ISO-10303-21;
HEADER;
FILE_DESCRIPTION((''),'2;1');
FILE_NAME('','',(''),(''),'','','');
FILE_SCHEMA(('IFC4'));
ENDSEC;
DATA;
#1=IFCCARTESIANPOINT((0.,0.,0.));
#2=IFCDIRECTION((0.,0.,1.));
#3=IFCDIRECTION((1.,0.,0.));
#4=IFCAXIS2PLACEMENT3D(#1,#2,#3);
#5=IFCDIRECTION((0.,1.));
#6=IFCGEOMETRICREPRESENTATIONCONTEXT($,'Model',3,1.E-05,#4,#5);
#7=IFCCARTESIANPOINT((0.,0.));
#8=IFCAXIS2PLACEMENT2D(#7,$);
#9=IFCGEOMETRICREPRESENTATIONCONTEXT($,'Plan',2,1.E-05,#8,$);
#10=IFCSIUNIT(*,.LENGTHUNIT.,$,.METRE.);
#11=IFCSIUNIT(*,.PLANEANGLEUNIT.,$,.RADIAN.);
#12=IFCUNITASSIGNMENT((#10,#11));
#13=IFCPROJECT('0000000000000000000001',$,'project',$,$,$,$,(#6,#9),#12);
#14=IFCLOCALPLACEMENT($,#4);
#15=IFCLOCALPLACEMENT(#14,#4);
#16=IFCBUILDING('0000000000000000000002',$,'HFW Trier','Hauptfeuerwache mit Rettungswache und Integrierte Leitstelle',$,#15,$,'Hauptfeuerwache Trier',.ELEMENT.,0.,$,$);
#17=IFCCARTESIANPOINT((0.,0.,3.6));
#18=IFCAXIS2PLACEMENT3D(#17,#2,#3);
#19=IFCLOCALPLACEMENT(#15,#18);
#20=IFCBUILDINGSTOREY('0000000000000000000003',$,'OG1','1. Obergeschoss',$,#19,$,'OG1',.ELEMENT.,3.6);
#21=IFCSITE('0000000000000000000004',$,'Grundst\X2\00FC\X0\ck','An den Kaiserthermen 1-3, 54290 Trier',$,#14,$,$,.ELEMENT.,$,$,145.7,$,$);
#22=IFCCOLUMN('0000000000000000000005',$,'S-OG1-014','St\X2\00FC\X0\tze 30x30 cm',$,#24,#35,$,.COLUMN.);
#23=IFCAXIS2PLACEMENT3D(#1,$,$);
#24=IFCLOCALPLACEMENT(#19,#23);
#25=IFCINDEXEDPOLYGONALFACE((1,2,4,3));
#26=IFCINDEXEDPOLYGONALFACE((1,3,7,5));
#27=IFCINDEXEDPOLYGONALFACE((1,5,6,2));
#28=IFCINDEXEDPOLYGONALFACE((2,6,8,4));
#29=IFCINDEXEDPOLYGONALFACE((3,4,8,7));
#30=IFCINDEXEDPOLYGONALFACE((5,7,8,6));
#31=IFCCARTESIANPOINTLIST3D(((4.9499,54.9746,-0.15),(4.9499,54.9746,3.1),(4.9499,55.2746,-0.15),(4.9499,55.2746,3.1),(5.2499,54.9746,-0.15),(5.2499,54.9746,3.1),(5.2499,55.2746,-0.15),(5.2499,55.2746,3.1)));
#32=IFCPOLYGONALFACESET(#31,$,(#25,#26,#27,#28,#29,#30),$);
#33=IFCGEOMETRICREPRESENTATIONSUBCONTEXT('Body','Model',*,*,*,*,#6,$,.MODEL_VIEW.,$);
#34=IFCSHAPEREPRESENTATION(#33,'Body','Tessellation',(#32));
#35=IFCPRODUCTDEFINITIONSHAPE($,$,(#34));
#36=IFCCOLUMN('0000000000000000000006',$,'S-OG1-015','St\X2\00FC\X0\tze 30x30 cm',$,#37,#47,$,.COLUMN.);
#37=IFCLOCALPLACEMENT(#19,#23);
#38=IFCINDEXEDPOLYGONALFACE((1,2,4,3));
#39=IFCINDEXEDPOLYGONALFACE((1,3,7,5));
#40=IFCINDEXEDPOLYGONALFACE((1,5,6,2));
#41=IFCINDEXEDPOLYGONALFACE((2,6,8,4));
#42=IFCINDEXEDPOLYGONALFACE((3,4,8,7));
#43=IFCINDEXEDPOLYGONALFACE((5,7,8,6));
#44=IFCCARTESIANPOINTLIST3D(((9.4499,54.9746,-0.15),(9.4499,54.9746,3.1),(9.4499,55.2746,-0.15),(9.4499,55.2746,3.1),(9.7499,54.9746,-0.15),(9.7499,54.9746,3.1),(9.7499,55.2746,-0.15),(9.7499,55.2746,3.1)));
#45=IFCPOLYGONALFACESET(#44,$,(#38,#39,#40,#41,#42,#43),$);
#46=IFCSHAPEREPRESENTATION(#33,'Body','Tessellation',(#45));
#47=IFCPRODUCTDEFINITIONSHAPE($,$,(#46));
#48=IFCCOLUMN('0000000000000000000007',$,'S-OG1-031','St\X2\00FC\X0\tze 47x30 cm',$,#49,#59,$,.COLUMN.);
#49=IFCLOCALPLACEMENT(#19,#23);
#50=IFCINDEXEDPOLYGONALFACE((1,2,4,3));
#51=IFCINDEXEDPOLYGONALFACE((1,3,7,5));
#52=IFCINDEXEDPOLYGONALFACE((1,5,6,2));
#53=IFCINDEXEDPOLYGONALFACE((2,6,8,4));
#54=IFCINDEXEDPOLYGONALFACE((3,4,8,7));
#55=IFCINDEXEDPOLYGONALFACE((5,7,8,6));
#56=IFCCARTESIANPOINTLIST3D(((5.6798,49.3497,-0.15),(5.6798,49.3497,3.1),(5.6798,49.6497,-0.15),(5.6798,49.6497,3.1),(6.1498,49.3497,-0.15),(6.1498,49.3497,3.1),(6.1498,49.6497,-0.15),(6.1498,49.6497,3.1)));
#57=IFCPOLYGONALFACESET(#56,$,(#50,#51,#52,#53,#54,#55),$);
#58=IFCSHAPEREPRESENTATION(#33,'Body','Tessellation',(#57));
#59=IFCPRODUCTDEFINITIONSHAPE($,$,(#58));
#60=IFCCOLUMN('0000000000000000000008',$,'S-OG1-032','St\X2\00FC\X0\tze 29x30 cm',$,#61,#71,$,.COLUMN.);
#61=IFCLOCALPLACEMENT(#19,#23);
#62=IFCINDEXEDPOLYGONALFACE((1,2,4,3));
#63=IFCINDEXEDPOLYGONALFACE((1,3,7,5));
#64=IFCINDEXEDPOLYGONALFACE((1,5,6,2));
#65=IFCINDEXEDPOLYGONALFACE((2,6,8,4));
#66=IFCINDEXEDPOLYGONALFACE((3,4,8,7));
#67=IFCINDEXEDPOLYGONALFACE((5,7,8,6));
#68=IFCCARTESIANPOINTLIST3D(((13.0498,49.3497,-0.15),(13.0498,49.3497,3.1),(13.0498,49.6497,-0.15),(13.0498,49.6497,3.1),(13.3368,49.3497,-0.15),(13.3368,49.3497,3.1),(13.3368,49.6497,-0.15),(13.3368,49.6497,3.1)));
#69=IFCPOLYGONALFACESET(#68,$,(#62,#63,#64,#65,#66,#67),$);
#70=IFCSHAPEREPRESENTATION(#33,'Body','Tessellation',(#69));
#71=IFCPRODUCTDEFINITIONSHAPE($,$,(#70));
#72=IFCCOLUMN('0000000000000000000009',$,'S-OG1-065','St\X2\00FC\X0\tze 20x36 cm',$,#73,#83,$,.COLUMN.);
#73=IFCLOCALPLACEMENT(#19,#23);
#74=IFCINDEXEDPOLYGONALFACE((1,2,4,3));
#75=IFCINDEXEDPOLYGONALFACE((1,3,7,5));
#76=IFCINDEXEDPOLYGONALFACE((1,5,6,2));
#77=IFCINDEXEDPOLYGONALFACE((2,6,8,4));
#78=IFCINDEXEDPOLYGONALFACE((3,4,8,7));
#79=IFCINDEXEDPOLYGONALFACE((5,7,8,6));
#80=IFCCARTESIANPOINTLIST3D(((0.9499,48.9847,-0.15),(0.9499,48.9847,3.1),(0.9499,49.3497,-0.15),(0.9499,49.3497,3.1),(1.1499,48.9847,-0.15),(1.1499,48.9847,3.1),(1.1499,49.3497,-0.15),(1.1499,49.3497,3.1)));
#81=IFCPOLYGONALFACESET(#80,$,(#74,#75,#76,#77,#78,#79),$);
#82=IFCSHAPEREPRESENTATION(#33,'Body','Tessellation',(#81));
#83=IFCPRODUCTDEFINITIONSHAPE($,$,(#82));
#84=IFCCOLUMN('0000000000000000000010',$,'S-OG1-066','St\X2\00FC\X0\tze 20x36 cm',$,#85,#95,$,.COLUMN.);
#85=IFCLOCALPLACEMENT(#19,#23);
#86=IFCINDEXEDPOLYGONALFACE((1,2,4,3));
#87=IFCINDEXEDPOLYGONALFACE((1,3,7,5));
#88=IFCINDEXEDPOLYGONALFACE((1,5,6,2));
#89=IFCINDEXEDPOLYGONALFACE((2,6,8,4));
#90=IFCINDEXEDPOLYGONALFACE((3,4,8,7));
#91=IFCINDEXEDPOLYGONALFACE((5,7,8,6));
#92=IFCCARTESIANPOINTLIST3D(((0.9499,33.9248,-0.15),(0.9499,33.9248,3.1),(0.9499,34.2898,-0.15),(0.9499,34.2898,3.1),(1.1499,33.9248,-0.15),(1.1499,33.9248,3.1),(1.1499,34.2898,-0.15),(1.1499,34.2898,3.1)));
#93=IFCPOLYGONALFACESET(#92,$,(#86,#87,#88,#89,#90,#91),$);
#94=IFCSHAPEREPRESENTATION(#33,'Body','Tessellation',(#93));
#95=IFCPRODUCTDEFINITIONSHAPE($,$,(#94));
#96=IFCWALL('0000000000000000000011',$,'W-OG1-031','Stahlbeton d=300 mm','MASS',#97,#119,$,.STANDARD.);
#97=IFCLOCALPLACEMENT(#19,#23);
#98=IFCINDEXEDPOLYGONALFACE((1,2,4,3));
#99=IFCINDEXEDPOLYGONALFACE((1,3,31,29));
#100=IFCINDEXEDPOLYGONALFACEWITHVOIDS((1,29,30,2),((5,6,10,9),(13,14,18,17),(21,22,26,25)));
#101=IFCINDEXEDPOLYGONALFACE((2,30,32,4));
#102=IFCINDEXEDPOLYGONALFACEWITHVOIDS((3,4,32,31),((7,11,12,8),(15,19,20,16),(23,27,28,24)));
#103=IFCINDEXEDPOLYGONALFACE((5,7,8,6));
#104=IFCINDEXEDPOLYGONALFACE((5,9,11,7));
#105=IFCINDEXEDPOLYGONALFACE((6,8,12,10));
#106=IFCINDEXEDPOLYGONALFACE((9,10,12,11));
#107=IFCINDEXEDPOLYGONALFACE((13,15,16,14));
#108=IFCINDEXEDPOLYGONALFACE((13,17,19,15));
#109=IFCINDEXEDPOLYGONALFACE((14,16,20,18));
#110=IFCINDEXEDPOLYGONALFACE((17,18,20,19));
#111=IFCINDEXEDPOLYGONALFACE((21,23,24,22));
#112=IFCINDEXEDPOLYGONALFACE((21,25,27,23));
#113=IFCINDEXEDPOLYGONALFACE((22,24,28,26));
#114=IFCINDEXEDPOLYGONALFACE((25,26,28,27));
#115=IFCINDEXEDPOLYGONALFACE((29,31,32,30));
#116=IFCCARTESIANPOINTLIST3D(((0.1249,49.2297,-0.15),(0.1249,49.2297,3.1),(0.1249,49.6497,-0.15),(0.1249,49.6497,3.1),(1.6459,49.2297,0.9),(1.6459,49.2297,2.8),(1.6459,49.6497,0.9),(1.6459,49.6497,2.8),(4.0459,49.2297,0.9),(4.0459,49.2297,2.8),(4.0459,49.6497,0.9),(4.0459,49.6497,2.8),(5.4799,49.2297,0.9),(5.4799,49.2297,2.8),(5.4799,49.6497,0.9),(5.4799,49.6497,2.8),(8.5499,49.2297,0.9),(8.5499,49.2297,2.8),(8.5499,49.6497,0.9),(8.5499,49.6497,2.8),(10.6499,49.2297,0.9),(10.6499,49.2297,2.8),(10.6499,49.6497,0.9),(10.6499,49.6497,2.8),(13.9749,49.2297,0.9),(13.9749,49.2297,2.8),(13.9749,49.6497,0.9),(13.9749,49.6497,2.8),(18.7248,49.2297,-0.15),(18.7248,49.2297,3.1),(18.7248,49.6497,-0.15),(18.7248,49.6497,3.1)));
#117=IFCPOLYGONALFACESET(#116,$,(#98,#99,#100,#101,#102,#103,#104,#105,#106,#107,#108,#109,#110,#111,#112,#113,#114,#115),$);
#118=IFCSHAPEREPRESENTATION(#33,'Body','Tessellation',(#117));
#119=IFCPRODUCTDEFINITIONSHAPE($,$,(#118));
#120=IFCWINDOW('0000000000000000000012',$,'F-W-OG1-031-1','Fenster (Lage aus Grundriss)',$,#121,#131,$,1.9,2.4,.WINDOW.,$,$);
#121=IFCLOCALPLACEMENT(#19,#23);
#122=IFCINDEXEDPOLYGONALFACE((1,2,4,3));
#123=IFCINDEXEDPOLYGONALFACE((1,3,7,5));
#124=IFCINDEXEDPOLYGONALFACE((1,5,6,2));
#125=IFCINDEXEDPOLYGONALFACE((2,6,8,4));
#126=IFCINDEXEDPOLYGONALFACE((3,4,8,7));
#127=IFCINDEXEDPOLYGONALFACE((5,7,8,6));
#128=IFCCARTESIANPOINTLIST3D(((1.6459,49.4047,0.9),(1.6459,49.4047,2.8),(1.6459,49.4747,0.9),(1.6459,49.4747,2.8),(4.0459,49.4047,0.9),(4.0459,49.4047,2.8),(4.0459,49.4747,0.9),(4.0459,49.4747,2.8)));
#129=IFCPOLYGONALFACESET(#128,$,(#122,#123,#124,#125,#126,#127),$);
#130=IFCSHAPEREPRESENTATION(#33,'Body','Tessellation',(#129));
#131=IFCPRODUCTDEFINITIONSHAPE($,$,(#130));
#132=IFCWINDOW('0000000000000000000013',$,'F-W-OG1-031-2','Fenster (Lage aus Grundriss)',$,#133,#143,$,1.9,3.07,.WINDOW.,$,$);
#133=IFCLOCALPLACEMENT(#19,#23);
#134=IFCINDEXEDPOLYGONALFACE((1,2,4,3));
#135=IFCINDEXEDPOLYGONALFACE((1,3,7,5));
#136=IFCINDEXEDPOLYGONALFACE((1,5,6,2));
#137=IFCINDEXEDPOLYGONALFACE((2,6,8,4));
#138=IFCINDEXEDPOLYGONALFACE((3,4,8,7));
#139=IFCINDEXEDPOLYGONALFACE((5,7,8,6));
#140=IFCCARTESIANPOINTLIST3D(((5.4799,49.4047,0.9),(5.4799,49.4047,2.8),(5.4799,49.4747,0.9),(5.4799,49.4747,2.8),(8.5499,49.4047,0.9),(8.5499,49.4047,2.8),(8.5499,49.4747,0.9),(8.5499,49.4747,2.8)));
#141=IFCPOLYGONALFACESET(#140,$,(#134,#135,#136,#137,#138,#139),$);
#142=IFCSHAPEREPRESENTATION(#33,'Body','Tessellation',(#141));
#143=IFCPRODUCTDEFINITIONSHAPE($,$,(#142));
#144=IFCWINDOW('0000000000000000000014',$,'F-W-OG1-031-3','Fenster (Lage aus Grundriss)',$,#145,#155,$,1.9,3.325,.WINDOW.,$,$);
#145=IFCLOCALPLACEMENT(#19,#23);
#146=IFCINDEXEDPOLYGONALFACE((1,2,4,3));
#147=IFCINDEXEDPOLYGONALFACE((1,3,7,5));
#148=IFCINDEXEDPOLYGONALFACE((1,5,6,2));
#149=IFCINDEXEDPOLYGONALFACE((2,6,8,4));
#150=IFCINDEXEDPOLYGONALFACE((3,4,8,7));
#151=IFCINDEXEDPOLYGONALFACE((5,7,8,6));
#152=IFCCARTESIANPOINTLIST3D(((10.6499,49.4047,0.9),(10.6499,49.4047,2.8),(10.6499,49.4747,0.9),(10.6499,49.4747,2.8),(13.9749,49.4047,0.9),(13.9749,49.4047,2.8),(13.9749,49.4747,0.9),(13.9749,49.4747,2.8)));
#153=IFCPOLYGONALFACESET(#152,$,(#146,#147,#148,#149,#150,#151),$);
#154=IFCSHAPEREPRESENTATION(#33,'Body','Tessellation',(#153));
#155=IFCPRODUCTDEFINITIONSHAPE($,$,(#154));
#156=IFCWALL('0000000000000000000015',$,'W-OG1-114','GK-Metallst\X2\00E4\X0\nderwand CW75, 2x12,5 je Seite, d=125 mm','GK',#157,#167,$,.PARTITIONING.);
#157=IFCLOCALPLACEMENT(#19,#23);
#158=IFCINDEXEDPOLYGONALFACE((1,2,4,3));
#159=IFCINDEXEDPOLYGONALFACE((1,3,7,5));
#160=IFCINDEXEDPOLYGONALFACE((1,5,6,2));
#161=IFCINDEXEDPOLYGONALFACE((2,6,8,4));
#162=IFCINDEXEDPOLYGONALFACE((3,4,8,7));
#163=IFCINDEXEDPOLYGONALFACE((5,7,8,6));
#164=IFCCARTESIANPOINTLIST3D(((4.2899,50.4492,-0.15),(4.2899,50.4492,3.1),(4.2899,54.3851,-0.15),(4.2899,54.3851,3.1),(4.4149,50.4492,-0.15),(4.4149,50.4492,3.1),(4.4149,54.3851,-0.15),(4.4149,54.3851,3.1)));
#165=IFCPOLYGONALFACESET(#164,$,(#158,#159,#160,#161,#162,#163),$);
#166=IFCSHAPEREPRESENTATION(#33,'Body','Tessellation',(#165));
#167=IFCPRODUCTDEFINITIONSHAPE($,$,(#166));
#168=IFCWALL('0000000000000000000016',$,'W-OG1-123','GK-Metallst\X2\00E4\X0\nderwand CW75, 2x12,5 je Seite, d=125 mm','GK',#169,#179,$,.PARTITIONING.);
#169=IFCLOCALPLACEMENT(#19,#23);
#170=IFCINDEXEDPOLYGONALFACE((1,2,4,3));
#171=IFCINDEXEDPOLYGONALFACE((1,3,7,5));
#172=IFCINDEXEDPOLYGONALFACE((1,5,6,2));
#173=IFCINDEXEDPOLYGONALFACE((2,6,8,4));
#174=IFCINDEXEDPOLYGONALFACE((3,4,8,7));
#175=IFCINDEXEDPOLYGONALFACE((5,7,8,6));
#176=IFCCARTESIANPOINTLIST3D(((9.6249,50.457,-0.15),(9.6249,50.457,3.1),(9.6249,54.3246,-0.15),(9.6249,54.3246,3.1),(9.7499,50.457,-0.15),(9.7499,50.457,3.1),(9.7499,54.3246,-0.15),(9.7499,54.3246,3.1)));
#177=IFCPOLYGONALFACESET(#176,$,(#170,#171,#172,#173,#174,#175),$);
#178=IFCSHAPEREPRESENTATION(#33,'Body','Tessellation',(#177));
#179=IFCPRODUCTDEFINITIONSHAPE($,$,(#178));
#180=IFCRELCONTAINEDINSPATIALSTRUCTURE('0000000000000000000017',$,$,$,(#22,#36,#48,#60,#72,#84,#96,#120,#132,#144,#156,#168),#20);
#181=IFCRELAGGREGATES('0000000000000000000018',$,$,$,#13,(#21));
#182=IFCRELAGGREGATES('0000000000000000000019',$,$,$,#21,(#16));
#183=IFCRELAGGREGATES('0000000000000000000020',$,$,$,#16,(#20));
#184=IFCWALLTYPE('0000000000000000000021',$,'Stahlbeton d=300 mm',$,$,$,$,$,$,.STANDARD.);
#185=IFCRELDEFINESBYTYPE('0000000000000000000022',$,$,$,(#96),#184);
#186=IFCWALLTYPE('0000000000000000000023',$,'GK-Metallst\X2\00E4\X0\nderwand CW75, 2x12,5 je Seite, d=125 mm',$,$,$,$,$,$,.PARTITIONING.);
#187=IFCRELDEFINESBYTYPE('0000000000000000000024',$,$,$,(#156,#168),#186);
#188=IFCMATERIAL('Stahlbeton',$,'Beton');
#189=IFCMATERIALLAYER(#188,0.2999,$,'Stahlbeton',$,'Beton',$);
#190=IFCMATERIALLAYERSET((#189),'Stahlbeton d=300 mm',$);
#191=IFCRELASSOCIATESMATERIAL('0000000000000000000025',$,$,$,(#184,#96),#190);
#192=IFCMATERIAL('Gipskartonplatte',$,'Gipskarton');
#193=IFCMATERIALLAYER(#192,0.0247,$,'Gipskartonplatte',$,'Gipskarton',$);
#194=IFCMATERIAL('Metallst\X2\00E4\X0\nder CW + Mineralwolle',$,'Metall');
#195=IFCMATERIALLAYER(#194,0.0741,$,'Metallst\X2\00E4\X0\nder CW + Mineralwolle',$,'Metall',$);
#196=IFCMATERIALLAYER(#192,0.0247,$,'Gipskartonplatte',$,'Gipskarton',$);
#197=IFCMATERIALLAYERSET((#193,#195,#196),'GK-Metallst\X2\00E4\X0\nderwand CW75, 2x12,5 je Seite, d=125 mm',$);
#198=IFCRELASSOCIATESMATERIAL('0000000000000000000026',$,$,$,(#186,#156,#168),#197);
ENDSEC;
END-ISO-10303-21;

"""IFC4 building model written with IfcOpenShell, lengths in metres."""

from ifc_helpers import new_model, si_unit, direction, frame, frame_2d, origin_with_axes, origin_2d, place, context, subcontext, project, spatial, rectangle, extrude, material, layer, layer_set, layer_usage, type_object, element, fill, save


model = new_model("IFC4")

# Units and contexts
model_context = context("Model", 3, precision=1e-05, world=origin_with_axes(), true_north=direction((0.0, 1.0)))
plan_context = context("Plan", 2, precision=1e-05, world=origin_2d())
body_context = subcontext(model_context, "Body", "Model", "MODEL_VIEW")
ifc_project = project(units=[si_unit("LENGTHUNIT", "METRE"), si_unit("PLANEANGLEUNIT", "RADIAN")], contexts=[model_context, plan_context])

# Site, building, storey
site_placement = place(None, origin_with_axes())
site = spatial("IfcSite", under=ifc_project, at=site_placement, Name="Grundstück", Description="An den Kaiserthermen 1-3, 54290 Trier", CompositionType="ELEMENT", RefElevation=145.7)
building_placement = place(site_placement, origin_with_axes())
building = spatial("IfcBuilding", under=site, at=building_placement, Name="HFW Trier", Description="Hauptfeuerwache mit Rettungswache und Integrierte Leitstelle", LongName="Hauptfeuerwache Trier", CompositionType="ELEMENT", ElevationOfRefHeight=0.0)
storey_placement = place(building_placement, frame((0.0, 0.0, 3.6), z_axis=(0.0, 0.0, 1.0), x_axis=(1.0, 0.0, 0.0)))
storey = spatial("IfcBuildingStorey", under=building, at=storey_placement, Name="OG1", Description="1. Obergeschoss", LongName="OG1", CompositionType="ELEMENT", Elevation=3.6)

# Columns
for number, where, z_axis, x_axis, name in (
    (1, (4.9499, 55.1246, -0.15), (0.0, 0.0, 1.0), (1.0, 0.0, 0.0), "S-OG1-014"),
    (2, (9.4499, 55.1246, -0.15), (0.0, 0.0, 1.0), (1.0, 0.0, 0.0), "S-OG1-015"),
):
    element("IfcColumn", number, at=place(storey_placement, frame(where, z_axis=z_axis, x_axis=x_axis)), inside=storey, Name=name, Description="Stütze 30x30 cm", PredefinedType="COLUMN", context=body_context, shape_type="SweptSolid", body=[
        extrude(rectangle(XDim=0.3, YDim=0.3, at=frame_2d((0.15, 0.0))), origin_with_axes(), (0.0, 0.0, 1.0), 3.25),
    ])
column_1_placement = place(storey_placement, frame((5.6798, 49.4997, -0.15), z_axis=(0.0, 0.0, 1.0), x_axis=(1.0, 0.0, 0.0)))
element("IfcColumn", 3, at=column_1_placement, inside=storey, Name="S-OG1-031", Description="Stütze 47x30 cm", PredefinedType="COLUMN", context=body_context, shape_type="SweptSolid", body=[
    extrude(rectangle(XDim=0.47, YDim=0.3, at=frame_2d((0.235, 0.0))), origin_with_axes(), (0.0, 0.0, 1.0), 3.25),
])
column_2_placement = place(storey_placement, frame((13.0498, 49.4997, -0.15), z_axis=(0.0, 0.0, 1.0), x_axis=(1.0, 0.0, 0.0)))
element("IfcColumn", 4, at=column_2_placement, inside=storey, Name="S-OG1-032", Description="Stütze 29x30 cm", PredefinedType="COLUMN", context=body_context, shape_type="SweptSolid", body=[
    extrude(rectangle(XDim=0.287, YDim=0.3, at=frame_2d((0.1435, 0.0))), origin_with_axes(), (0.0, 0.0, 1.0), 3.25),
])
for number, where, z_axis, x_axis, name in (
    (5, (0.9499, 49.1672, -0.15), (0.0, 0.0, 1.0), (1.0, 0.0, 0.0), "S-OG1-065"),
    (6, (0.9499, 34.1073, -0.15), (0.0, 0.0, 1.0), (1.0, 0.0, 0.0), "S-OG1-066"),
):
    element("IfcColumn", number, at=place(storey_placement, frame(where, z_axis=z_axis, x_axis=x_axis)), inside=storey, Name=name, Description="Stütze 20x36 cm", PredefinedType="COLUMN", context=body_context, shape_type="SweptSolid", body=[
        extrude(rectangle(XDim=0.2, YDim=0.365, at=frame_2d((0.1, 0.0))), origin_with_axes(), (0.0, 0.0, 1.0), 3.25),
    ])

# Wall, openings, windows
ifc_material_1 = material(Name="Stahlbeton", Category="Beton")
ifc_layer_1 = layer(ifc_material_1, 0.2999, Name="Stahlbeton", Category="Beton")
ifc_layer_set_1 = layer_set([ifc_layer_1], Name="Stahlbeton d=300 mm")
ifc_layer_usage_1 = layer_usage(ifc_layer_set_1, "AXIS2", "POSITIVE", -0.21)
wall_type_1 = type_object("IfcWallType", Name="Stahlbeton d=300 mm", PredefinedType="STANDARD", material=ifc_layer_set_1)
wall_1_placement = place(storey_placement, frame((0.1249, 49.4397, -0.15), z_axis=(0.0, 0.0, 1.0), x_axis=(1.0, 0.0, 0.0)))
wall_1 = element("IfcWall", 7, at=wall_1_placement, inside=storey, type_object=wall_type_1, material=ifc_layer_usage_1, Name="W-OG1-031", Description="Stahlbeton d=300 mm", ObjectType="MASS", PredefinedType="STANDARD", context=body_context, shape_type="SweptSolid", body=[
    extrude(rectangle(XDim=18.5999, YDim=0.42, at=frame_2d((9.2999, 0.0))), origin_with_axes(), (0.0, 0.0, 1.0), 3.25),
])
opening_1_placement = place(wall_1_placement, frame((1.521, 0.0, 0.0), z_axis=(0.0, 0.0, 1.0), x_axis=(1.0, 0.0, 0.0)))
opening_1 = element("IfcOpeningElement", 8, at=opening_1_placement, cuts=wall_1, PredefinedType="OPENING", context=body_context, shape_type="SweptSolid", body=[
    extrude(rectangle(XDim=2.4, YDim=0.52, at=frame_2d((1.2, 0.0))), frame((0.0, 0.0, 1.05), z_axis=(0.0, 0.0, 1.0), x_axis=(1.0, 0.0, 0.0)), (0.0, 0.0, 1.0), 1.9),
])
opening_2_placement = place(wall_1_placement, frame((5.355, 0.0, 0.0), z_axis=(0.0, 0.0, 1.0), x_axis=(1.0, 0.0, 0.0)))
opening_2 = element("IfcOpeningElement", 9, at=opening_2_placement, cuts=wall_1, PredefinedType="OPENING", context=body_context, shape_type="SweptSolid", body=[
    extrude(rectangle(XDim=3.07, YDim=0.52, at=frame_2d((1.535, 0.0))), frame((0.0, 0.0, 1.05), z_axis=(0.0, 0.0, 1.0), x_axis=(1.0, 0.0, 0.0)), (0.0, 0.0, 1.0), 1.9),
])
opening_3_placement = place(wall_1_placement, frame((10.525, 0.0, 0.0), z_axis=(0.0, 0.0, 1.0), x_axis=(1.0, 0.0, 0.0)))
opening_3 = element("IfcOpeningElement", 10, at=opening_3_placement, cuts=wall_1, PredefinedType="OPENING", context=body_context, shape_type="SweptSolid", body=[
    extrude(rectangle(XDim=3.325, YDim=0.52, at=frame_2d((1.6625, 0.0))), frame((0.0, 0.0, 1.05), z_axis=(0.0, 0.0, 1.0), x_axis=(1.0, 0.0, 0.0)), (0.0, 0.0, 1.0), 1.9),
])
window_1_placement = place(wall_1_placement, frame((1.521, 0.0, 0.0), z_axis=(0.0, 0.0, 1.0), x_axis=(1.0, 0.0, 0.0)))
window_1 = element("IfcWindow", 11, at=window_1_placement, inside=storey, Name="F-W-OG1-031-1", Description="Fenster (Lage aus Grundriss)", OverallHeight=1.9, OverallWidth=2.4, PredefinedType="WINDOW", context=body_context, shape_type="SweptSolid", body=[
    extrude(rectangle(XDim=2.4, YDim=0.07, at=frame_2d((1.2, 0.0))), frame((0.0, 0.0, 1.05), z_axis=(0.0, 0.0, 1.0), x_axis=(1.0, 0.0, 0.0)), (0.0, 0.0, 1.0), 1.9),
])
fill(opening_1, window_1)
window_2_placement = place(wall_1_placement, frame((5.355, 0.0, 0.0), z_axis=(0.0, 0.0, 1.0), x_axis=(1.0, 0.0, 0.0)))
window_2 = element("IfcWindow", 12, at=window_2_placement, inside=storey, Name="F-W-OG1-031-2", Description="Fenster (Lage aus Grundriss)", OverallHeight=1.9, OverallWidth=3.07, PredefinedType="WINDOW", context=body_context, shape_type="SweptSolid", body=[
    extrude(rectangle(XDim=3.07, YDim=0.07, at=frame_2d((1.535, 0.0))), frame((0.0, 0.0, 1.05), z_axis=(0.0, 0.0, 1.0), x_axis=(1.0, 0.0, 0.0)), (0.0, 0.0, 1.0), 1.9),
])
fill(opening_2, window_2)
window_3_placement = place(wall_1_placement, frame((10.525, 0.0, 0.0), z_axis=(0.0, 0.0, 1.0), x_axis=(1.0, 0.0, 0.0)))
window_3 = element("IfcWindow", 13, at=window_3_placement, inside=storey, Name="F-W-OG1-031-3", Description="Fenster (Lage aus Grundriss)", OverallHeight=1.9, OverallWidth=3.325, PredefinedType="WINDOW", context=body_context, shape_type="SweptSolid", body=[
    extrude(rectangle(XDim=3.325, YDim=0.07, at=frame_2d((1.6625, 0.0))), frame((0.0, 0.0, 1.05), z_axis=(0.0, 0.0, 1.0), x_axis=(1.0, 0.0, 0.0)), (0.0, 0.0, 1.0), 1.9),
])
fill(opening_3, window_3)

# Walls
ifc_material_2 = material(Name="Gipskartonplatte", Category="Gipskarton")
ifc_layer_2 = layer(ifc_material_2, 0.0247, Name="Gipskartonplatte", Category="Gipskarton")
ifc_material_3 = material(Name="Metallständer CW + Mineralwolle", Category="Metall")
ifc_layer_3 = layer(ifc_material_3, 0.0741, Name="Metallständer CW + Mineralwolle", Category="Metall")
ifc_layer_4 = layer(ifc_material_2, 0.0247, Name="Gipskartonplatte", Category="Gipskarton")
ifc_layer_set_2 = layer_set([ifc_layer_2, ifc_layer_3, ifc_layer_4], Name="GK-Metallständerwand CW75, 2x12,5 je Seite, d=125 mm")
ifc_layer_usage_2 = layer_usage(ifc_layer_set_2, "AXIS2", "POSITIVE", -0.0625)
wall_type_2 = type_object("IfcWallType", Name="GK-Metallständerwand CW75, 2x12,5 je Seite, d=125 mm", PredefinedType="PARTITIONING", material=ifc_layer_set_2)
wall_2_placement = place(storey_placement, frame((4.3524, 54.3851, -0.15), z_axis=(0.0, 0.0, 1.0), x_axis=(0.0, -1.0, 0.0)))
element("IfcWall", 14, at=wall_2_placement, inside=storey, type_object=wall_type_2, material=ifc_layer_usage_2, Name="W-OG1-114", Description="GK-Metallständerwand CW75, 2x12,5 je Seite, d=125 mm", ObjectType="GK", PredefinedType="PARTITIONING", context=body_context, shape_type="SweptSolid", body=[
    extrude(rectangle(XDim=3.9359, YDim=0.125, at=frame_2d((1.968, 0.0))), origin_with_axes(), (0.0, 0.0, 1.0), 3.25),
])
ifc_layer_usage_3 = layer_usage(ifc_layer_set_2, "AXIS2", "POSITIVE", -0.0625)
wall_3_placement = place(storey_placement, frame((9.6874, 54.3246, -0.15), z_axis=(0.0, 0.0, 1.0), x_axis=(0.0, -1.0, 0.0)))
element("IfcWall", 15, at=wall_3_placement, inside=storey, type_object=wall_type_2, material=ifc_layer_usage_3, Name="W-OG1-123", Description="GK-Metallständerwand CW75, 2x12,5 je Seite, d=125 mm", ObjectType="GK", PredefinedType="PARTITIONING", context=body_context, shape_type="SweptSolid", body=[
    extrude(rectangle(XDim=3.8676, YDim=0.125, at=frame_2d((1.9338, 0.0))), origin_with_axes(), (0.0, 0.0, 1.0), 3.25),
])

save(model, "model.ifc")
